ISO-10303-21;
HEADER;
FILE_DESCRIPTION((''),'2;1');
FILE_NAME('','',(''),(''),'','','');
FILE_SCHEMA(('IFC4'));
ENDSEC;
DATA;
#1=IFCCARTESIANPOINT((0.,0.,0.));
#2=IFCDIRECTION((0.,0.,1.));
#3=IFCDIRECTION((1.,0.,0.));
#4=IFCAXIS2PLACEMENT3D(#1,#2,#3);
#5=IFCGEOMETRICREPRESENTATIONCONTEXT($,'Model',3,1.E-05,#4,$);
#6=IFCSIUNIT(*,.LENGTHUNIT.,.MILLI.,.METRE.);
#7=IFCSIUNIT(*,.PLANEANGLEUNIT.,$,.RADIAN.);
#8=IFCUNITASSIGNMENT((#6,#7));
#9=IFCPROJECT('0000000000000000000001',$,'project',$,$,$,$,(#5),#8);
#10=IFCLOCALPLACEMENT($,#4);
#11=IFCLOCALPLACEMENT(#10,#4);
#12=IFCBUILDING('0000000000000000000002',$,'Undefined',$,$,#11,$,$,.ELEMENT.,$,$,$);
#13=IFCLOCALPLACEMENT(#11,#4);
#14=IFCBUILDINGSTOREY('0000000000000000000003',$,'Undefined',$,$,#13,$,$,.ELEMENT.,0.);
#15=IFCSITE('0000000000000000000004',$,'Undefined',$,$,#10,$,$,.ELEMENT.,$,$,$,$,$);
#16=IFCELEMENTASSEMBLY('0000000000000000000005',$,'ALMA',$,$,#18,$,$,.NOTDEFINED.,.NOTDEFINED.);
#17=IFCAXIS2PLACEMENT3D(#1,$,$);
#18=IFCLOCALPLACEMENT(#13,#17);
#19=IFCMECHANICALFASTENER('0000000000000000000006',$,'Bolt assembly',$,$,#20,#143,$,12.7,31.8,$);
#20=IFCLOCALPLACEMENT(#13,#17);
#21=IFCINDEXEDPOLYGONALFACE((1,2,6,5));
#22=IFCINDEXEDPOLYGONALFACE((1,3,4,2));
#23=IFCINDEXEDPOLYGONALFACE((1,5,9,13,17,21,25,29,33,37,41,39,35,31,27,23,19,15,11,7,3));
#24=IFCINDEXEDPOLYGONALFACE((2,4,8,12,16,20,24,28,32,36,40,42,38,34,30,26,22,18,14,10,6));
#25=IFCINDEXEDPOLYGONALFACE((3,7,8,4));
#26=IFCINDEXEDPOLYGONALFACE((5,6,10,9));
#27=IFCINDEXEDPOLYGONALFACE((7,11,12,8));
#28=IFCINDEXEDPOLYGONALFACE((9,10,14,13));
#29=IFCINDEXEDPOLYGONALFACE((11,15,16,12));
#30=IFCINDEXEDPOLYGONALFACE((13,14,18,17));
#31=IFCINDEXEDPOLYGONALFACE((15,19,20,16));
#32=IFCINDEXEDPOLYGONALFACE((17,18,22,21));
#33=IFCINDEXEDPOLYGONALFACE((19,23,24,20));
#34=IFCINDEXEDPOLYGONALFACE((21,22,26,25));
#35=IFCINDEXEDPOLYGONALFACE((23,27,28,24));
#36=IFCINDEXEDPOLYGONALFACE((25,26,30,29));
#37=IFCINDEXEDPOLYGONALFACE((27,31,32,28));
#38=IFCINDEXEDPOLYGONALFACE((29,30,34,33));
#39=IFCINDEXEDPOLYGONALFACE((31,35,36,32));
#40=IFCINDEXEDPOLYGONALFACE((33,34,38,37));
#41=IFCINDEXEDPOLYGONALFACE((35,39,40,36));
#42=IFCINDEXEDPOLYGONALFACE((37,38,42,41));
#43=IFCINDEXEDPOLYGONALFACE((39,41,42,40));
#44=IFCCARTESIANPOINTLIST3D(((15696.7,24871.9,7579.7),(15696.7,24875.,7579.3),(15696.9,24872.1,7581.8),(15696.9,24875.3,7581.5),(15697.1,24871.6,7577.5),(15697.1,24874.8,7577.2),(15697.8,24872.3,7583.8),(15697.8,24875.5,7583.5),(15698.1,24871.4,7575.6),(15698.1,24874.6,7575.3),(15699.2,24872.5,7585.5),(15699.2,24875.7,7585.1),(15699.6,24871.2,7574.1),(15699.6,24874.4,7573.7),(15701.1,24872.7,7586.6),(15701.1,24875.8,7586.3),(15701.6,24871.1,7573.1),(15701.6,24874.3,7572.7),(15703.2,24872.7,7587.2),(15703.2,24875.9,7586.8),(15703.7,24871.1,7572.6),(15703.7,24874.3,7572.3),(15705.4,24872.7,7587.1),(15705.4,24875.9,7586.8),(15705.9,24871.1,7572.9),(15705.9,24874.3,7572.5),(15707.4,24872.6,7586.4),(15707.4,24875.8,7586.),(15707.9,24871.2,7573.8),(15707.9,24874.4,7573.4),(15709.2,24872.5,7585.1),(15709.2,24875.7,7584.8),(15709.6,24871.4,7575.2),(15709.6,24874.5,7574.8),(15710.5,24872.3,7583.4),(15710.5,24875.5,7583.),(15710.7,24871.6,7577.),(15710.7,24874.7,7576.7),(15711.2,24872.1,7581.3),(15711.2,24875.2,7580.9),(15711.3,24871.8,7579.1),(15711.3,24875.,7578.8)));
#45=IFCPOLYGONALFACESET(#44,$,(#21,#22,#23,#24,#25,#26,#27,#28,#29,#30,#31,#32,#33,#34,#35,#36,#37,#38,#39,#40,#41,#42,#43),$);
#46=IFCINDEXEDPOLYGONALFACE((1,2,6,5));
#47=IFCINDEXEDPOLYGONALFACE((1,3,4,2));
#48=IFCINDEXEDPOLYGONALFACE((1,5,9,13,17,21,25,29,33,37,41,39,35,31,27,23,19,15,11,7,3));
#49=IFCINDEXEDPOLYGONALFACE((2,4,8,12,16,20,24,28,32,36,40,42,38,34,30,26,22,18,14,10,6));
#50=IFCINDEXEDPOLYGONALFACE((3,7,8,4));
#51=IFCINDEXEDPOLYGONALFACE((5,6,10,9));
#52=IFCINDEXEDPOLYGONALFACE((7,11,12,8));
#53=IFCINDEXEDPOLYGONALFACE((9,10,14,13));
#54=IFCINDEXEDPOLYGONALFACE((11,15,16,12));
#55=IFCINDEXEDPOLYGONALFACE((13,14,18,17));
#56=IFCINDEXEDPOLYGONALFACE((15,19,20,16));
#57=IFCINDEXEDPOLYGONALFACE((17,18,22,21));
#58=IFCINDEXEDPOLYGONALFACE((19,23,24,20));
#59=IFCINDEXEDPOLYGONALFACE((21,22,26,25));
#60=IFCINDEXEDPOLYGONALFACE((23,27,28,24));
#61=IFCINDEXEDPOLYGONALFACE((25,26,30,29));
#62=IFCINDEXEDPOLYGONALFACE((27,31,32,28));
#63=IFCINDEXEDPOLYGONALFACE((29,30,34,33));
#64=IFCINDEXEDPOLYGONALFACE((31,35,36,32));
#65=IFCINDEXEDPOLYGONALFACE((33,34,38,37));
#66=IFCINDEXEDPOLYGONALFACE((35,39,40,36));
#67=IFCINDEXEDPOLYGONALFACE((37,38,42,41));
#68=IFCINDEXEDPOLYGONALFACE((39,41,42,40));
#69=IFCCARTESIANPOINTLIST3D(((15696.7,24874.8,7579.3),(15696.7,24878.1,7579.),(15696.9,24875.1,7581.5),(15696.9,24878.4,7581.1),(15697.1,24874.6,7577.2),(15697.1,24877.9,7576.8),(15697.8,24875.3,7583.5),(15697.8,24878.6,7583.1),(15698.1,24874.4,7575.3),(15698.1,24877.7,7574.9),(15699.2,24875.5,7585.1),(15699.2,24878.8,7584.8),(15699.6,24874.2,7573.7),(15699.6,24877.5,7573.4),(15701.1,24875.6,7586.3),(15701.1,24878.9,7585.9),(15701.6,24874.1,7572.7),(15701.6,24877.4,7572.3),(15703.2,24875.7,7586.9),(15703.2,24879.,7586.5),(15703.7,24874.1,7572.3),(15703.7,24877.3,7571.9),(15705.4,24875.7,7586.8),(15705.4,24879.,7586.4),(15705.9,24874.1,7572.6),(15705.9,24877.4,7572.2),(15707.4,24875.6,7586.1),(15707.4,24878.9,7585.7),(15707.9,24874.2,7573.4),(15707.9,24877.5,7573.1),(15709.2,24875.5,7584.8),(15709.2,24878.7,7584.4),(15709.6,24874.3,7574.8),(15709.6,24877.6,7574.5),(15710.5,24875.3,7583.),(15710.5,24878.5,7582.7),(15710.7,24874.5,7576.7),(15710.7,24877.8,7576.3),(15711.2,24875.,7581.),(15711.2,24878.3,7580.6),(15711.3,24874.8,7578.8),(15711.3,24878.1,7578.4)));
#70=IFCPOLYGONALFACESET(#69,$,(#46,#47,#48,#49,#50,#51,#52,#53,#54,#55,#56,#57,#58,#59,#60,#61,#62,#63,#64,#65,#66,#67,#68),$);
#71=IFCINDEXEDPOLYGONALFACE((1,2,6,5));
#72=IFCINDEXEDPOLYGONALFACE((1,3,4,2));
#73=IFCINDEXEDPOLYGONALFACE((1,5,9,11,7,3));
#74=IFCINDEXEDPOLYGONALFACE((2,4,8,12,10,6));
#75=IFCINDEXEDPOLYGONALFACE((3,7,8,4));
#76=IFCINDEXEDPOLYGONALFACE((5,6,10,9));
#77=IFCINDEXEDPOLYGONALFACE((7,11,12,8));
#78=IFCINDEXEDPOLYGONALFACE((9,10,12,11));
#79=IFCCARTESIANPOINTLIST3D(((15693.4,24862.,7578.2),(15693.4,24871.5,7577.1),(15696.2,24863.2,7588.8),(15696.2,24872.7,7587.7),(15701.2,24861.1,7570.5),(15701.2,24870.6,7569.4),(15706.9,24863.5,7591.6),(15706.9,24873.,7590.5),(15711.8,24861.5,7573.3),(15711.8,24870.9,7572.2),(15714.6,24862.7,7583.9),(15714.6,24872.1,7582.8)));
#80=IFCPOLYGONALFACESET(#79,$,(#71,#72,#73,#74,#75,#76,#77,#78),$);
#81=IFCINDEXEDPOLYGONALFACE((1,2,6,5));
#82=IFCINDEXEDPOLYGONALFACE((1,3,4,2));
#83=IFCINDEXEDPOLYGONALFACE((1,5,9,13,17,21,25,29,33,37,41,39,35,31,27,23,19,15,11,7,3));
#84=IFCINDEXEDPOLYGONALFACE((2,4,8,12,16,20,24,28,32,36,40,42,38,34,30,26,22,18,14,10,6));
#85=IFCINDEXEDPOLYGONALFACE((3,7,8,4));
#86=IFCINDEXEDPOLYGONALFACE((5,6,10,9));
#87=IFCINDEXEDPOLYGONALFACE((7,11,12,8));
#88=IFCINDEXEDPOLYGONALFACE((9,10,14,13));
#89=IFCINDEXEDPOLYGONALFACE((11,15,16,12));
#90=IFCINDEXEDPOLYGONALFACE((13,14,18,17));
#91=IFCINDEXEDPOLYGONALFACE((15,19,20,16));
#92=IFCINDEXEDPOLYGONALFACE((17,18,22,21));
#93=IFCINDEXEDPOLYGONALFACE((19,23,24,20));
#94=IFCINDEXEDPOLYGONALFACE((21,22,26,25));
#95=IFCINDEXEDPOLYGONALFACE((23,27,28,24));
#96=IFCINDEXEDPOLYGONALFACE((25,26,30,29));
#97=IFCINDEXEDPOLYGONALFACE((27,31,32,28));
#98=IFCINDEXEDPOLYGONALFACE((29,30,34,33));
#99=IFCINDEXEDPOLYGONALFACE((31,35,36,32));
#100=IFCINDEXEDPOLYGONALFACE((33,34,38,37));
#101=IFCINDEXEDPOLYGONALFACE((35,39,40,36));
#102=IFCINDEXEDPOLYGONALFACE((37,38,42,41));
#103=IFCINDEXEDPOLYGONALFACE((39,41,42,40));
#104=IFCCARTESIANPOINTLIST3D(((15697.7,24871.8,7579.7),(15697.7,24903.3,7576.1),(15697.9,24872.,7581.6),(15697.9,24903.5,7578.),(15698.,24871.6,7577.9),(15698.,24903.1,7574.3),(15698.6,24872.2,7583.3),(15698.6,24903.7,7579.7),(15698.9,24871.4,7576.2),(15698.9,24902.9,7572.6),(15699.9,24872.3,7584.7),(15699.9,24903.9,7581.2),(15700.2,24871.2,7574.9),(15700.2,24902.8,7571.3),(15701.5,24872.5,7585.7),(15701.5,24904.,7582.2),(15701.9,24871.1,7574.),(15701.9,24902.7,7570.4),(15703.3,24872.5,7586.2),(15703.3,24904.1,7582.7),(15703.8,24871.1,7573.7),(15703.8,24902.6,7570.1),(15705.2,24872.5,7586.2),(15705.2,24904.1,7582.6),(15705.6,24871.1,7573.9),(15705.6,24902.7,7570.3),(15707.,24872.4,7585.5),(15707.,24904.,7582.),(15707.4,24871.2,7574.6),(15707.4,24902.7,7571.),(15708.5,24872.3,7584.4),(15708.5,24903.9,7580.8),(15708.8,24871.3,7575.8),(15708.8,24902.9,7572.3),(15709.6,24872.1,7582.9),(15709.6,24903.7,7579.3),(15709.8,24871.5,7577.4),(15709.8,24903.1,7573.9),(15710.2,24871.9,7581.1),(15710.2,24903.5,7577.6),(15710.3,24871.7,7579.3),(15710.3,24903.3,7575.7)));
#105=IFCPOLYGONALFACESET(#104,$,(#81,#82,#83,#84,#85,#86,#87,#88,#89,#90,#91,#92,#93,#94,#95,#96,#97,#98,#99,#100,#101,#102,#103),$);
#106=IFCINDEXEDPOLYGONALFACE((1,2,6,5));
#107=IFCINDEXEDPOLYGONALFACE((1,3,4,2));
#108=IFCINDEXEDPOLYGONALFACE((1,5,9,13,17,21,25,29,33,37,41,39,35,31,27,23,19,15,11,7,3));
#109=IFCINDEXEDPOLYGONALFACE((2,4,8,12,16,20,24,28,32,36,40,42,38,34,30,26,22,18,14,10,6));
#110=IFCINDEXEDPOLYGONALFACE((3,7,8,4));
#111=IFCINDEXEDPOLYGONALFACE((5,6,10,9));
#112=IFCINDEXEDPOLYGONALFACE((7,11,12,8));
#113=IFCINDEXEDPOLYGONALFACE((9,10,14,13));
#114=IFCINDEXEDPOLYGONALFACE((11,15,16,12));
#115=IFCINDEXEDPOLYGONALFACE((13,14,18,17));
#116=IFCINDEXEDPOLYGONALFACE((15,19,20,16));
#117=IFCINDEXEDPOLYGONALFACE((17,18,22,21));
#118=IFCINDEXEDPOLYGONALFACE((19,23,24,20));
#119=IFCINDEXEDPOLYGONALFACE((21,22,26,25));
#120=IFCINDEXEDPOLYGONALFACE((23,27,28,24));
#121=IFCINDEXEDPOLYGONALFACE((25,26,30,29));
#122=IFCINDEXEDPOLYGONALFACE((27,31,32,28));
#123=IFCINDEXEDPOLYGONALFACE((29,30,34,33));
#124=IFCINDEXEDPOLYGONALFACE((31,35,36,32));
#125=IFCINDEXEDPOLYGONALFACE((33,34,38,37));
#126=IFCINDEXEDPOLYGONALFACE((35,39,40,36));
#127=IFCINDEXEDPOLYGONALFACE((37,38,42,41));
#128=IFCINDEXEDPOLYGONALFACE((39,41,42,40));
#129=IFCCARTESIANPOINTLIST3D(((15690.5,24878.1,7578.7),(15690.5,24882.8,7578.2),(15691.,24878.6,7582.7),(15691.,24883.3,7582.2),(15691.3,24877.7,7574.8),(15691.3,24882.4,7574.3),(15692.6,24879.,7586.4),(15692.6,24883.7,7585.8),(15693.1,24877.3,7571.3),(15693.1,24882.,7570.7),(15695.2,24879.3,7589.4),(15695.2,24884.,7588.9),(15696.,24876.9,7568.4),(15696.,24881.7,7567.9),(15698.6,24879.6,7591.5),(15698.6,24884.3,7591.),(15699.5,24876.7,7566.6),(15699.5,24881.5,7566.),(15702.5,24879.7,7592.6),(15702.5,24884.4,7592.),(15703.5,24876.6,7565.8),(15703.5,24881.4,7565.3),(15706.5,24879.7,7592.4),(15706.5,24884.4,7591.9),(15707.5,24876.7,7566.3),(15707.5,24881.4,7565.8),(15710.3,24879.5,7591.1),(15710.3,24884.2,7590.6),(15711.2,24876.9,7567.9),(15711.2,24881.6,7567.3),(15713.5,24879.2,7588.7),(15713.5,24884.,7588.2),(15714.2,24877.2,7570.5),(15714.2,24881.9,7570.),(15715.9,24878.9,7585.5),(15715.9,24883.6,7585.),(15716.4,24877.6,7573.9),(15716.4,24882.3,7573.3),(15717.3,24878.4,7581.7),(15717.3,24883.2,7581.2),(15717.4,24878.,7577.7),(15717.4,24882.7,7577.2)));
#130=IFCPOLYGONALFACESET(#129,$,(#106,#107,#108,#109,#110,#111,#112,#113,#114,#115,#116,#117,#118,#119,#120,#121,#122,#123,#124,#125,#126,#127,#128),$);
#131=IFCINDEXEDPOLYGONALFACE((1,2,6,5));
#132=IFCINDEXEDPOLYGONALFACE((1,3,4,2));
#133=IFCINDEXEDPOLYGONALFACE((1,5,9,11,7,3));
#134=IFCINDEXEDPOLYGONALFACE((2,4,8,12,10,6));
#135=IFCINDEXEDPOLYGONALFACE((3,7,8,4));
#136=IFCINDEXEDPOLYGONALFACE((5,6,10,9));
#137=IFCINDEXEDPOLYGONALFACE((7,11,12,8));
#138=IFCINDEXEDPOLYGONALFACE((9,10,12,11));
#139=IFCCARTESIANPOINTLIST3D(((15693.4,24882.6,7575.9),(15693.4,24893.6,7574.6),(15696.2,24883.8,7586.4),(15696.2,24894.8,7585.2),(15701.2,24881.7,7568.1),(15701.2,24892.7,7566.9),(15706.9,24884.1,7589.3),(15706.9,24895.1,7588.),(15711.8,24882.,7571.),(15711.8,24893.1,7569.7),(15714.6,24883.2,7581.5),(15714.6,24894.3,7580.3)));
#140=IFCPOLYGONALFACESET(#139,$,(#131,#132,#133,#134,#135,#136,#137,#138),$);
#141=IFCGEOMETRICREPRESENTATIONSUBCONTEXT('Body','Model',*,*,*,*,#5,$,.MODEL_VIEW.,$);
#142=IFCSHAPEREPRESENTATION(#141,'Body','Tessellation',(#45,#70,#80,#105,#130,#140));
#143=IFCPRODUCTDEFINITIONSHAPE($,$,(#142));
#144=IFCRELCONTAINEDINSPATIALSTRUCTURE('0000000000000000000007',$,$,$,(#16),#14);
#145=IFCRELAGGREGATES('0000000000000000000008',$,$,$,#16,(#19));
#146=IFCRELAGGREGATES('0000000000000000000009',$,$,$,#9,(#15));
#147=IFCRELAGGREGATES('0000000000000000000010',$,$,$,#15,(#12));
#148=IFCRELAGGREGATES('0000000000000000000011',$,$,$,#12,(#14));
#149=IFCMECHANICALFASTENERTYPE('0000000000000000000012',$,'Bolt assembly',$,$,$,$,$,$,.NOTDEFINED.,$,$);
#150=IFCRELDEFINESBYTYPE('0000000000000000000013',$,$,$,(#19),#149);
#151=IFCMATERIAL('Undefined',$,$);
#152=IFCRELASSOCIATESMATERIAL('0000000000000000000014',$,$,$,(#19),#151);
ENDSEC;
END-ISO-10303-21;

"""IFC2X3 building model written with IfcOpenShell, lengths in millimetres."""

from ifc_helpers import new_model, si_unit, frame, origin_with_axes, origin_2d_with_axis, place, context, subcontext, project, spatial, polyline, circle, outline, extrude, source, transform, mapped, material, type_object, element, aggregate, save


model = new_model("IFC2X3")

# Units and contexts
model_context = context("Model", 3, precision=1e-05, world=origin_with_axes())
body_context = subcontext(model_context, "Body", "Model", "MODEL_VIEW")
ifc_project = project(units=[si_unit("LENGTHUNIT", "METRE", prefix="MILLI"), si_unit("PLANEANGLEUNIT", "RADIAN")], contexts=[model_context])

# Site, building, storey
site_placement = place(None, origin_with_axes())
site = spatial("IfcSite", under=ifc_project, at=site_placement, Name="Undefined", CompositionType="ELEMENT")
building_placement = place(site_placement, origin_with_axes())
building = spatial("IfcBuilding", under=site, at=building_placement, Name="Undefined", CompositionType="ELEMENT")
storey_placement = place(building_placement, origin_with_axes())
storey = spatial("IfcBuildingStorey", under=building, at=storey_placement, Name="Undefined", CompositionType="ELEMENT", Elevation=0.0)

# Element assembly
assembly_1_placement = place(storey_placement, origin_with_axes())
assembly_1 = element("IfcElementAssembly", 1, at=assembly_1_placement, inside=storey, Name="ALMA", AssemblyPlace="NOTDEFINED", PredefinedType="NOTDEFINED")

# Mechanical fastener
ifc_material_1 = material(Name="Undefined")
mechanical_fastener_type = type_object("IfcMechanicalFastenerType", Name="Bolt assembly")
shared_shape_1 = source(origin_with_axes(), body_context, "Body", "SweptSolid", [
    extrude(circle(Radius=7.3, at=origin_2d_with_axis()), frame((0.0, 0.1, 0.0), z_axis=(0.0, 1.0, 0.0), x_axis=(1.0, 0.0, 0.0)), (0.0, 0.0, 1.0), 3.2),
    extrude(circle(Radius=7.3, at=origin_2d_with_axis()), frame((0.0, 3.1, 0.0), z_axis=(0.0, 1.0, 0.0), x_axis=(1.0, 0.0, 0.0)), (0.0, 0.0, 1.0), 3.3),
    extrude(outline(polyline([(9.5, -5.5), (9.5, 5.5), (0.0, 11.0), (-9.5, 5.5), (-9.5, -5.5), (0.0, -11.0), (9.5, -5.5)])), frame((0.0, -9.5, 0.0), z_axis=(0.0, 1.0, 0.0), x_axis=(1.0, 0.0, 0.0)), (0.0, 0.0, 1.0), 9.5),
    extrude(circle(Radius=6.3, at=origin_2d_with_axis()), frame((0.0, 0.0, 0.0), z_axis=(0.0, 1.0, 0.0), x_axis=(1.0, 0.0, 0.0)), (0.0, 0.0, 1.0), 31.8),
    extrude(circle(Radius=13.5, at=origin_2d_with_axis()), frame((0.0, 6.4, 0.0), z_axis=(0.0, 1.0, 0.0), x_axis=(1.0, 0.0, 0.0)), (0.0, 0.0, 1.0), 4.8),
    extrude(outline(polyline([(9.5, -5.5), (9.5, 5.5), (0.0, 11.0), (-9.5, 5.5), (-9.5, -5.5), (0.0, -11.0), (9.5, -5.5)])), frame((0.0, 11.2, 0.0), z_axis=(0.0, 1.0, 0.0), x_axis=(1.0, 0.0, 0.0)), (0.0, 0.0, 1.0), 11.1),
])
mechanical_fastener_1_placement = place(assembly_1_placement, frame((15704.0, 24871.8, 7580.0), z_axis=(-0.707107, 0.079651, 0.702606), x_axis=(0.707107, 0.079651, 0.702606)))
mechanical_fastener_1 = element("IfcMechanicalFastener", 2, at=mechanical_fastener_1_placement, type_object=mechanical_fastener_type, material=ifc_material_1, Name="Bolt assembly", NominalDiameter=12.7, NominalLength=31.8, context=body_context, shape_type="MappedRepresentation", body=[
    mapped(shared_shape_1, transform((0.0, 0.0, 0.0))),
])

aggregate(assembly_1, [mechanical_fastener_1])

save(model, "model.ifc")
